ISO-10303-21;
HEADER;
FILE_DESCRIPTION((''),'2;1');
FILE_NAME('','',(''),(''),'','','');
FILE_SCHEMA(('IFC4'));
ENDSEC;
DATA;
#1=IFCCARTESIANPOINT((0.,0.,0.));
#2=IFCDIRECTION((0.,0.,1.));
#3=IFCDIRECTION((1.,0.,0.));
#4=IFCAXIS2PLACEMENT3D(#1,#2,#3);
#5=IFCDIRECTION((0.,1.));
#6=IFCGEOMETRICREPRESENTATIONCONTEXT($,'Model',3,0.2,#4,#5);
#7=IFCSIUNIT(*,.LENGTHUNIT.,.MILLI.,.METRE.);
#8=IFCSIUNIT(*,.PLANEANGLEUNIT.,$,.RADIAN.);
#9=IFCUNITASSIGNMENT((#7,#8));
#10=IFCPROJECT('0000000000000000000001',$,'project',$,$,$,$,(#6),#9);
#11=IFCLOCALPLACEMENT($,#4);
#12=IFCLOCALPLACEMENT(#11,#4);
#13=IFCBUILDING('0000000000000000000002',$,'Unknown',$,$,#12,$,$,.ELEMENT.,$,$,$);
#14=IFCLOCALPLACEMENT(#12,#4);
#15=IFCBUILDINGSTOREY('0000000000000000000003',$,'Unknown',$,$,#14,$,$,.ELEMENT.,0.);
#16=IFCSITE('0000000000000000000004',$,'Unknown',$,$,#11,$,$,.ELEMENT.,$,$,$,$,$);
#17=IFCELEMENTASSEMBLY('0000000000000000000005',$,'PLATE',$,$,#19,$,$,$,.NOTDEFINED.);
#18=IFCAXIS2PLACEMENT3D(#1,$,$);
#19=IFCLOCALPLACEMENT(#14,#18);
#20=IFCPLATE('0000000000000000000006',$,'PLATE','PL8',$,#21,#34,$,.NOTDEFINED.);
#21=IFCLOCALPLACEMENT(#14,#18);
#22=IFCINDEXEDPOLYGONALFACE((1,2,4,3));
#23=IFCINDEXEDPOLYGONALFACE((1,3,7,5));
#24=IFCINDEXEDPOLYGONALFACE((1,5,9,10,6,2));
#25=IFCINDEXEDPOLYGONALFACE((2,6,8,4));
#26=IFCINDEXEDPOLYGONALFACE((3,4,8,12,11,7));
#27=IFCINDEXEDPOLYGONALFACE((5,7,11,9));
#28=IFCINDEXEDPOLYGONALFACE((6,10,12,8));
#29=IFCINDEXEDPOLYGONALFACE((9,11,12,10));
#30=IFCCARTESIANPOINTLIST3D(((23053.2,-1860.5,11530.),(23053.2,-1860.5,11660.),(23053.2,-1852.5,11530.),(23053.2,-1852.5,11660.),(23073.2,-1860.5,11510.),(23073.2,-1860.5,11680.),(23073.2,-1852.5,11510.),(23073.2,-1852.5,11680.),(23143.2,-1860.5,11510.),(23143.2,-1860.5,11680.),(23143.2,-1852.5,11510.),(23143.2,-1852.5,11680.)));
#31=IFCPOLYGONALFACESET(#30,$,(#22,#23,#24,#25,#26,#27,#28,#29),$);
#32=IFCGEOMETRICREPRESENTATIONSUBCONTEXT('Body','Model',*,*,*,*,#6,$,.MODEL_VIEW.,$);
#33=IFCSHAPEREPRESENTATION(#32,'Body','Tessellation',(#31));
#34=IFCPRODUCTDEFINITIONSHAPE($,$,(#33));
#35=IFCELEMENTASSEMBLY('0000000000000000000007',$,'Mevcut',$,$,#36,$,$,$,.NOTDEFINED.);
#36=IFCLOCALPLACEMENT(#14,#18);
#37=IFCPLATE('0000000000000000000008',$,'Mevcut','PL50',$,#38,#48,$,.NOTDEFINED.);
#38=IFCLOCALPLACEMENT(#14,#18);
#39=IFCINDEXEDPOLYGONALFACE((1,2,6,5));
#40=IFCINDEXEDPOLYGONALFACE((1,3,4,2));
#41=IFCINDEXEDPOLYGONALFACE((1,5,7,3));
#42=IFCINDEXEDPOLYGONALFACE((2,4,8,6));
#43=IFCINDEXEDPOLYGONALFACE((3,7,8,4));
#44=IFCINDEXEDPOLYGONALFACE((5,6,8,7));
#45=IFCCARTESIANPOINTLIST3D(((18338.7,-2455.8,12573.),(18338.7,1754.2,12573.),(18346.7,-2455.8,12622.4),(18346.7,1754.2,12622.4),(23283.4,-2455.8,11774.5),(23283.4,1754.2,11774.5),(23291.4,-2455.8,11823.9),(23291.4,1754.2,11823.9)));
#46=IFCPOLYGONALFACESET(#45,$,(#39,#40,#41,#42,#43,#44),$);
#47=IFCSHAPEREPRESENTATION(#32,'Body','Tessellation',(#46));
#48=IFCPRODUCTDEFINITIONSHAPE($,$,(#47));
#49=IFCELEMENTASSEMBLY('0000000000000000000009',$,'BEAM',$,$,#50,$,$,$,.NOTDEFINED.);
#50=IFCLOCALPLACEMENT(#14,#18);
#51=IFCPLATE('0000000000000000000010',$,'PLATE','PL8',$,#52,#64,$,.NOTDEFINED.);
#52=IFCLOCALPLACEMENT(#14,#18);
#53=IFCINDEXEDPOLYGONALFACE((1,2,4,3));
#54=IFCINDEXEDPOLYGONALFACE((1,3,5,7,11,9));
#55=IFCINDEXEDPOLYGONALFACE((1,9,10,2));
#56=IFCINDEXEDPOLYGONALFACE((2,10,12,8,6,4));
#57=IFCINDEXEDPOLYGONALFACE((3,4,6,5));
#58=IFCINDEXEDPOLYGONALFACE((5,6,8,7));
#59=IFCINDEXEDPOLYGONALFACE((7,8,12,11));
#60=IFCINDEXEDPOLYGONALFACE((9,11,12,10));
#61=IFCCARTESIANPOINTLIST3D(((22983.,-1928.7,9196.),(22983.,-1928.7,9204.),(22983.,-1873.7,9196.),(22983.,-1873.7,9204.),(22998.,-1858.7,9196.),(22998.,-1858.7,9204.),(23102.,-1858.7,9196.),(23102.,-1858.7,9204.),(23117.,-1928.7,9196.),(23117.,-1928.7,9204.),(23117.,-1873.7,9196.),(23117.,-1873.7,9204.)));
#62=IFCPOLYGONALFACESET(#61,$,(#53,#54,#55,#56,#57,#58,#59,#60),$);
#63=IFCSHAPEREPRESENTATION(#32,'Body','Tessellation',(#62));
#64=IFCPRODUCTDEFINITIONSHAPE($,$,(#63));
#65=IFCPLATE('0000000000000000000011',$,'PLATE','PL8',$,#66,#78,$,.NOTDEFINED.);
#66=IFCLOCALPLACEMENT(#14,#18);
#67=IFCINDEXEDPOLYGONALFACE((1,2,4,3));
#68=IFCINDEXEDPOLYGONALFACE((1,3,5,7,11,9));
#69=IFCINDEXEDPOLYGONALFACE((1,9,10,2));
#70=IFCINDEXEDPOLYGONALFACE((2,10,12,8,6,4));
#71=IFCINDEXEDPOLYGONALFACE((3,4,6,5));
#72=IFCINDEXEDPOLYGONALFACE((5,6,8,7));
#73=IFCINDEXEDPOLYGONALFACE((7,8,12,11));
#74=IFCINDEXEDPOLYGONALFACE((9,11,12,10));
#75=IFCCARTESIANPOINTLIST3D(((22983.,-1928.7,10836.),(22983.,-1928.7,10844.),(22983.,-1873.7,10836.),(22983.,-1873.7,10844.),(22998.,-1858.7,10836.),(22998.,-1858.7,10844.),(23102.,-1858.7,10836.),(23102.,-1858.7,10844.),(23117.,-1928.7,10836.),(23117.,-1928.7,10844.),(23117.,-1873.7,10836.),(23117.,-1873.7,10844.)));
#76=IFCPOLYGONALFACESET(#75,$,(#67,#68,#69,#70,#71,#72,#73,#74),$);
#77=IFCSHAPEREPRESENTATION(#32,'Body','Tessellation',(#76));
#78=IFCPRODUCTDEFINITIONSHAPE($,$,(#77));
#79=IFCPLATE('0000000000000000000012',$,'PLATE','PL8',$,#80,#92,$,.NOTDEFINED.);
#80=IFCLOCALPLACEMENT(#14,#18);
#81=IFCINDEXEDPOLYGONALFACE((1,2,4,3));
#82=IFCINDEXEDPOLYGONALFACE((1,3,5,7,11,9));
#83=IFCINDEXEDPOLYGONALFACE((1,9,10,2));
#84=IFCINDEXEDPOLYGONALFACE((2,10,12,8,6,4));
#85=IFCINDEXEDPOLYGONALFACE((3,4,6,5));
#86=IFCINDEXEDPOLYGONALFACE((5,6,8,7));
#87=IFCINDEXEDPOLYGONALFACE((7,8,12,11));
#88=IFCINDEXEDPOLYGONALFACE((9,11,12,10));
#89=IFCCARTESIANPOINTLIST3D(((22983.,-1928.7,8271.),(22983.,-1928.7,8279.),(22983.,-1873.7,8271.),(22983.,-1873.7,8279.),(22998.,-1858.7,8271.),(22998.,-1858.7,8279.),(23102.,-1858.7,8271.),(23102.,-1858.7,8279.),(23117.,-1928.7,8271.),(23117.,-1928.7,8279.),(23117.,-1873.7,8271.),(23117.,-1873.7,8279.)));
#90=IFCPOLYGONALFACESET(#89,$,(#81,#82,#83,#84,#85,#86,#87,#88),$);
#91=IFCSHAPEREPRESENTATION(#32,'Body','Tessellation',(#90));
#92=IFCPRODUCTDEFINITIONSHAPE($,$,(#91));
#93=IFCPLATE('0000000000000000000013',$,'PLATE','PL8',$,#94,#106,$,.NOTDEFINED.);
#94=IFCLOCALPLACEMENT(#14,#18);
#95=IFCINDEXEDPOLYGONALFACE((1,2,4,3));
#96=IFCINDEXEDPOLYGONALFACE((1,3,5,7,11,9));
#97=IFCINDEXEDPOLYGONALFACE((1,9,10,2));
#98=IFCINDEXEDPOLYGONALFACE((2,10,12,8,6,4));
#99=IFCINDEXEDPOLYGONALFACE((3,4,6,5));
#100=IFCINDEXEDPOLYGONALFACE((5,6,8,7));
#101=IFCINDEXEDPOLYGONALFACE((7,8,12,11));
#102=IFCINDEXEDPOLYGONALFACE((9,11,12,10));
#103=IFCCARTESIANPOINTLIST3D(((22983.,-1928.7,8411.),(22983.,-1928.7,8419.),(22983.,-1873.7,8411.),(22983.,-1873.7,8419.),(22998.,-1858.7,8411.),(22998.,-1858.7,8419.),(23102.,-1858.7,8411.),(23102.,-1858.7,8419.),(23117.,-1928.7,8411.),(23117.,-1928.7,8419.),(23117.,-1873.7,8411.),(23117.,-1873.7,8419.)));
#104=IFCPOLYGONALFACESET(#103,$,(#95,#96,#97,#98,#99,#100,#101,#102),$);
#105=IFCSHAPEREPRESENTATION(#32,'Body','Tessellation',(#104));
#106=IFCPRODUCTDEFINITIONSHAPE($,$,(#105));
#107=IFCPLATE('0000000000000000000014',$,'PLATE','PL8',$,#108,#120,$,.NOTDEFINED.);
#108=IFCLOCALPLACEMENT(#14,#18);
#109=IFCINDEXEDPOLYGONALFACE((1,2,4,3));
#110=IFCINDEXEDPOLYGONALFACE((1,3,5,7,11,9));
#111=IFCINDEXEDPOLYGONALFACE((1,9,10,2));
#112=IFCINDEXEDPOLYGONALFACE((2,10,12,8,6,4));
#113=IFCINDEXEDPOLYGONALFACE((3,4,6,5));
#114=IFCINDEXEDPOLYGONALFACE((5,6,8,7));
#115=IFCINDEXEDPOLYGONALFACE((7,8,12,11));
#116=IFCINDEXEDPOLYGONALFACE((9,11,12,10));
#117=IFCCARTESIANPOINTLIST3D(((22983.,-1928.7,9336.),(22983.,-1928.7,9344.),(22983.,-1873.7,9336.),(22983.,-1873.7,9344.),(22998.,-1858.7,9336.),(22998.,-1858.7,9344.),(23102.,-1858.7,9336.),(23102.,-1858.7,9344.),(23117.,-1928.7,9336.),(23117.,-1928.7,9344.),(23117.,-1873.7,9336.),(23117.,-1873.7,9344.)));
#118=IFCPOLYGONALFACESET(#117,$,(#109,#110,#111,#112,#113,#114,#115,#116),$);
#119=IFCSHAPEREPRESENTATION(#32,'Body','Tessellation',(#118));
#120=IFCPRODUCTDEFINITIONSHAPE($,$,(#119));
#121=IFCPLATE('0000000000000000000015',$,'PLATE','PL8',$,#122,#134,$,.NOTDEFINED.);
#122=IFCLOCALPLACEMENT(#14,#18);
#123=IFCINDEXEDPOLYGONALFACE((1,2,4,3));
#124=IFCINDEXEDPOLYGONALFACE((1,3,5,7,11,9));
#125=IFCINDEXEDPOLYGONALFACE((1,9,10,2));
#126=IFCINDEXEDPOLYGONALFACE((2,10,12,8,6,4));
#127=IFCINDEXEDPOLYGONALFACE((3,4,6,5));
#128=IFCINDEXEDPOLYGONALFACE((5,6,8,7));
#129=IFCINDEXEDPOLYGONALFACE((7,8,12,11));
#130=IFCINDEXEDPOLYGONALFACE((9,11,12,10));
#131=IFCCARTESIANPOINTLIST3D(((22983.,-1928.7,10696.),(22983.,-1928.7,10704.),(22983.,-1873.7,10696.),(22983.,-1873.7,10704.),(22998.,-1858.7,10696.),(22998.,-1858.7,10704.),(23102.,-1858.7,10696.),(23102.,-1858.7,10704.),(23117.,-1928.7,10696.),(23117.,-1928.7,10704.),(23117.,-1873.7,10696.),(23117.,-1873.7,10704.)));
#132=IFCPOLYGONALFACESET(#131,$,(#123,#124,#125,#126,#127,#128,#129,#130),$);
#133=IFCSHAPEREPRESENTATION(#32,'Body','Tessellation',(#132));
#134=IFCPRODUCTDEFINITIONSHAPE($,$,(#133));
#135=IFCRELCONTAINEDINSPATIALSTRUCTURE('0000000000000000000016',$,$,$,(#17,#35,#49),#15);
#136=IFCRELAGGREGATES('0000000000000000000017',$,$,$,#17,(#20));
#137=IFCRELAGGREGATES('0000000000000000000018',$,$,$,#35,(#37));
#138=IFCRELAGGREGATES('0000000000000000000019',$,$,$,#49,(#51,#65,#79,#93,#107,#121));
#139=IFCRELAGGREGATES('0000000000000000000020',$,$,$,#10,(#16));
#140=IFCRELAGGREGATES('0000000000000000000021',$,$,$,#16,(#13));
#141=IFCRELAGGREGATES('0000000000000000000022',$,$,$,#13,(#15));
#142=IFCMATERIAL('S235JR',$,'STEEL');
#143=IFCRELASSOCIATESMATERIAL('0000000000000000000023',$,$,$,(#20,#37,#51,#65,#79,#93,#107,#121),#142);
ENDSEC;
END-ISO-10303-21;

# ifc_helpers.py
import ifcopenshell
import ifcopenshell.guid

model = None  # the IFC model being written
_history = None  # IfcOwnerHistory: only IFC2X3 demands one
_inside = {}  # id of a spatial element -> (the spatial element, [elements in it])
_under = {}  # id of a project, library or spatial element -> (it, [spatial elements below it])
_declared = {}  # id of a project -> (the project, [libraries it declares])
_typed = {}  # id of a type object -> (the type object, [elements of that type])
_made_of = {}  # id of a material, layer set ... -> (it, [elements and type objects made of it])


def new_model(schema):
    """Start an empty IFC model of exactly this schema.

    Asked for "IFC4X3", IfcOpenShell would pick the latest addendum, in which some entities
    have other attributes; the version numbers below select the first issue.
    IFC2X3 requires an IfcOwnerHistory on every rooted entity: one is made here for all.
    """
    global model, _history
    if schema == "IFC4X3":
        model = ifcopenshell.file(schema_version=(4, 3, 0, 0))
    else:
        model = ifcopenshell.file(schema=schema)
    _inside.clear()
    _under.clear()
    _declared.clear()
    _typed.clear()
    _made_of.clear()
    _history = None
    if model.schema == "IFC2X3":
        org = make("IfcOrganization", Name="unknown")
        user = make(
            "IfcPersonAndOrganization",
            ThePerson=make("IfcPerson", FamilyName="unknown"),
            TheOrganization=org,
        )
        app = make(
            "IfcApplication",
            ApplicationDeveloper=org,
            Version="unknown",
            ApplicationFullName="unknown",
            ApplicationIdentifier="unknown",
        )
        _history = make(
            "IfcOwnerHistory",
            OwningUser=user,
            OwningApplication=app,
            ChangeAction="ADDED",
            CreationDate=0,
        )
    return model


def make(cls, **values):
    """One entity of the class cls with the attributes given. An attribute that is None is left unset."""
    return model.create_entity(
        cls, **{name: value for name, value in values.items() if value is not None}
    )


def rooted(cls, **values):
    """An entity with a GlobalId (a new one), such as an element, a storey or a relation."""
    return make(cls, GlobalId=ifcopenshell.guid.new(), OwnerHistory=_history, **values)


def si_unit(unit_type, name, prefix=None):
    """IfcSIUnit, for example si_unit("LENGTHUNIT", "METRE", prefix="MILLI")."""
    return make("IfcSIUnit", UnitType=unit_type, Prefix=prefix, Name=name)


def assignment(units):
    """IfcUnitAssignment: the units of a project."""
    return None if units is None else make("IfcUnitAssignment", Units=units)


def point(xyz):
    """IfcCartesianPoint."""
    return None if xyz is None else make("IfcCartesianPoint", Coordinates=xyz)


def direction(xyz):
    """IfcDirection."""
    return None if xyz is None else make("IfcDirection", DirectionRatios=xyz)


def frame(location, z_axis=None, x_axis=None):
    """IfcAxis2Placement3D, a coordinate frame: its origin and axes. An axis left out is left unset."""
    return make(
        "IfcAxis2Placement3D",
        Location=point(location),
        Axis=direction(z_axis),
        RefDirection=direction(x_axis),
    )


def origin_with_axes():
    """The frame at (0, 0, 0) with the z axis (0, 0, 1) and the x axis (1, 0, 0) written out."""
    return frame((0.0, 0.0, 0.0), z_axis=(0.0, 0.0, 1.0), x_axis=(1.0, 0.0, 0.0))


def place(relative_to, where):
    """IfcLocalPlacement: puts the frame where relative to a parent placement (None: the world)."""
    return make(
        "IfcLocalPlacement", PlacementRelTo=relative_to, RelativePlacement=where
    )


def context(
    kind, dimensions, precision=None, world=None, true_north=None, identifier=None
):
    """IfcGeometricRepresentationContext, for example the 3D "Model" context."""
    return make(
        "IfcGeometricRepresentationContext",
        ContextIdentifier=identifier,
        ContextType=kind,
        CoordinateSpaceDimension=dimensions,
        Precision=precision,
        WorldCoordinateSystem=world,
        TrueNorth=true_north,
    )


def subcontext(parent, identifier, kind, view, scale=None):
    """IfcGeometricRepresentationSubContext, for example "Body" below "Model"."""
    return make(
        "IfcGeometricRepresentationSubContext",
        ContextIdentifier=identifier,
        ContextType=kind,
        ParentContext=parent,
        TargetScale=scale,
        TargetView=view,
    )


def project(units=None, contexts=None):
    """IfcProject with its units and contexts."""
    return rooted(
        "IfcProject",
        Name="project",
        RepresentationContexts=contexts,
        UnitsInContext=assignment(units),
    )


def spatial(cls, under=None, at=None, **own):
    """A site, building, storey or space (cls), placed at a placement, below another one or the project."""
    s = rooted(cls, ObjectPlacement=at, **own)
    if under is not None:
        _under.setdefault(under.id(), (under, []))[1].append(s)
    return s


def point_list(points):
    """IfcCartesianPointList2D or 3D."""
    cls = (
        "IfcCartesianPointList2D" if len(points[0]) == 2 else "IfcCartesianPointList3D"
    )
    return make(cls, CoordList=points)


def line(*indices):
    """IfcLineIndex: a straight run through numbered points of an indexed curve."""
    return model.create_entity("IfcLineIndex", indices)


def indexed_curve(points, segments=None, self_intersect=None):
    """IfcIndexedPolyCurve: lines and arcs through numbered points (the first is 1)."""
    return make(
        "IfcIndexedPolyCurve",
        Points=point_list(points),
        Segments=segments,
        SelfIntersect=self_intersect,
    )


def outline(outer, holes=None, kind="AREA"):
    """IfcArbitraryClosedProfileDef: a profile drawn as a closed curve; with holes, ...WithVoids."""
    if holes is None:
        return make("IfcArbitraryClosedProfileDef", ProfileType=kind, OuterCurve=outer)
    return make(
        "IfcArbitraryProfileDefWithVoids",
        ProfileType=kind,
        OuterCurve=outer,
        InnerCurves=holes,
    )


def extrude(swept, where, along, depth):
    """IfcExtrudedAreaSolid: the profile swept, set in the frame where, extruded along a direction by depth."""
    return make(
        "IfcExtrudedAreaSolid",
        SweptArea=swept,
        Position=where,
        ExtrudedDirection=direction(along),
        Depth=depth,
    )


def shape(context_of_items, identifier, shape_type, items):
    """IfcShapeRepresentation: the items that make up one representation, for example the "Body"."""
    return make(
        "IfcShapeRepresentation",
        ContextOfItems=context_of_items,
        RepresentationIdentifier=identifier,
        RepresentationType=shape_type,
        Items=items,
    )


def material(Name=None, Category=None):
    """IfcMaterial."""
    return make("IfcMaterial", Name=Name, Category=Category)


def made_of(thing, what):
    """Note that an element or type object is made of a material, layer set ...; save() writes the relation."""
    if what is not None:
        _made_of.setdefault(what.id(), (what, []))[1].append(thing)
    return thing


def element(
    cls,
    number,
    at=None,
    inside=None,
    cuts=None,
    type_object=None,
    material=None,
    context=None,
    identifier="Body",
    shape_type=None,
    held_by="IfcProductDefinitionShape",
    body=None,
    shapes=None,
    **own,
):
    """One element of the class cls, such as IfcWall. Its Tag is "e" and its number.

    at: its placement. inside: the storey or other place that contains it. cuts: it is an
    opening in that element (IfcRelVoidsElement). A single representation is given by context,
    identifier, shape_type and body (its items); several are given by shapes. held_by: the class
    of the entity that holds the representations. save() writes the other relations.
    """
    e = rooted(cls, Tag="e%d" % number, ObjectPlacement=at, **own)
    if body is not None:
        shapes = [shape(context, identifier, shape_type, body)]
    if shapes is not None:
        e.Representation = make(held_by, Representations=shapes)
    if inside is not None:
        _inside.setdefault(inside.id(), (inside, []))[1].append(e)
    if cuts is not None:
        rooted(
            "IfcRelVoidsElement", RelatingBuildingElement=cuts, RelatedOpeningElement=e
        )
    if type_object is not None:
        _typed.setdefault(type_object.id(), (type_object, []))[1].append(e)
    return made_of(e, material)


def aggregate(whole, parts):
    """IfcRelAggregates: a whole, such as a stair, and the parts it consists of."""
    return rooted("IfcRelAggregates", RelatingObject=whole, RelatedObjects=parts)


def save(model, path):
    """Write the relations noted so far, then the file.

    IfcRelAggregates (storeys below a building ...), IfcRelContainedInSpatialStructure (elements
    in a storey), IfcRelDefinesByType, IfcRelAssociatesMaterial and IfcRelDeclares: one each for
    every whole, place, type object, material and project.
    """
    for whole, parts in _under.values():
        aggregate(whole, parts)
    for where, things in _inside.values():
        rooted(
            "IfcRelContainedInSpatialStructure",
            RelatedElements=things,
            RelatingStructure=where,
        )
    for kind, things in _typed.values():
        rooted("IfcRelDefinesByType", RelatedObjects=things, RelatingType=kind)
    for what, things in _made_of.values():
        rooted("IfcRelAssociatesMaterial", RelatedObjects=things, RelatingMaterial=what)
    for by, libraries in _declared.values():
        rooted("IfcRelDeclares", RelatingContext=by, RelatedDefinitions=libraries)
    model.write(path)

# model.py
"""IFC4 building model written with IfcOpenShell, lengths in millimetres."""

from ifc_helpers import new_model, si_unit, direction, frame, origin_with_axes, place, context, subcontext, project, spatial, line, indexed_curve, outline, extrude, material, element, aggregate, save


model = new_model("IFC4")

# Units and contexts
model_context = context("Model", 3, precision=0.2, world=origin_with_axes(), true_north=direction((0.0, 1.0)))
body_context = subcontext(model_context, "Body", "Model", "MODEL_VIEW")
ifc_project = project(units=[si_unit("LENGTHUNIT", "METRE", prefix="MILLI"), si_unit("PLANEANGLEUNIT", "RADIAN")], contexts=[model_context])

# Site, building, storey
site_placement = place(None, origin_with_axes())
site = spatial("IfcSite", under=ifc_project, at=site_placement, Name="Unknown", CompositionType="ELEMENT")
building_placement = place(site_placement, origin_with_axes())
building = spatial("IfcBuilding", under=site, at=building_placement, Name="Unknown", CompositionType="ELEMENT")
storey_placement = place(building_placement, origin_with_axes())
storey = spatial("IfcBuildingStorey", under=building, at=storey_placement, Name="Unknown", CompositionType="ELEMENT", Elevation=0.0)

# Shared definitions
ifc_material = material(Name="S235JR", Category="STEEL")

# Element assemblies, plates
assembly_1_placement = place(storey_placement, frame((23053.2, -1856.5, 11510.0), z_axis=(0.0, -1.0, 0.0), x_axis=(1.0, 0.0, 0.0)))
assembly_1 = element("IfcElementAssembly", 1, at=assembly_1_placement, inside=storey, Name="PLATE", PredefinedType="NOTDEFINED")
plate_1_placement = place(assembly_1_placement, origin_with_axes())
plate_1 = element("IfcPlate", 2, at=plate_1_placement, material=ifc_material, Name="PLATE", Description="PL8", PredefinedType="NOTDEFINED", context=body_context, shape_type="SolidModel", body=[
    extrude(outline(indexed_curve([(0.0, 20.0), (20.0, 0.0), (90.0, 0.0), (90.0, 170.0), (20.0, 170.0), (0.0, 150.0)], segments=[line(1, 2, 3, 4, 5, 6, 1)])), frame((0.0, 0.0, 4.0), z_axis=(0.0, 0.0, 1.0), x_axis=(1.0, 0.0, 0.0)), (0.0, 0.0, -1.0), 8.0),
])
aggregate(assembly_1, [plate_1])
assembly_2_placement = place(storey_placement, frame((18342.7, 1754.2, 12597.7), z_axis=(0.159427, 0.0, 0.98721), x_axis=(0.0, -1.0, 0.0)))
assembly_2 = element("IfcElementAssembly", 3, at=assembly_2_placement, inside=storey, Name="Mevcut", PredefinedType="NOTDEFINED")
plate_2_placement = place(assembly_2_placement, origin_with_axes())
plate_2 = element("IfcPlate", 4, at=plate_2_placement, material=ifc_material, Name="Mevcut", Description="PL50", PredefinedType="NOTDEFINED", context=body_context, shape_type="SolidModel", body=[
    extrude(outline(indexed_curve([(0.0, 0.0), (4210.0, 0.0), (4210.0, 5008.7), (0.0, 5008.7)], segments=[line(1, 2, 3, 4, 1)])), frame((0.0, 0.0, 25.0), z_axis=(0.0, 0.0, 1.0), x_axis=(1.0, 0.0, 0.0)), (0.0, 0.0, -1.0), 50.0),
])
aggregate(assembly_2, [plate_2])

# Element assembly, plates
assembly_3_placement = place(storey_placement, frame((23050.0, -1854.9, 11625.0), z_axis=(0.0, -1.0, 0.0), x_axis=(0.0, 0.0, -1.0)))
assembly_3 = element("IfcElementAssembly", 5, at=assembly_3_placement, inside=storey, Name="BEAM", PredefinedType="NOTDEFINED")
plate_3_placement = place(assembly_3_placement, frame((2425.0, -67.0, 3.8), z_axis=(-1.0, 0.0, 0.0), x_axis=(0.0, 0.0, 1.0)))
plate_3 = element("IfcPlate", 6, at=plate_3_placement, material=ifc_material, Name="PLATE", Description="PL8", PredefinedType="NOTDEFINED", context=body_context, shape_type="SolidModel", body=[
    extrude(outline(indexed_curve([(0.0, 15.0), (15.0, 0.0), (70.0, 0.0), (70.0, 134.0), (15.0, 134.0), (0.0, 119.0)], segments=[line(1, 2, 3, 4, 5, 6, 1)])), frame((0.0, 0.0, 4.0), z_axis=(0.0, 0.0, 1.0), x_axis=(1.0, 0.0, 0.0)), (0.0, 0.0, -1.0), 8.0),
])
plate_4_placement = place(assembly_3_placement, frame((785.0, -67.0, 3.8), z_axis=(-1.0, 0.0, 0.0), x_axis=(0.0, 0.0, 1.0)))
plate_4 = element("IfcPlate", 7, at=plate_4_placement, material=ifc_material, Name="PLATE", Description="PL8", PredefinedType="NOTDEFINED", context=body_context, shape_type="SolidModel", body=[
    extrude(outline(indexed_curve([(0.0, 15.0), (15.0, 0.0), (70.0, 0.0), (70.0, 134.0), (15.0, 134.0), (0.0, 119.0)], segments=[line(1, 2, 3, 4, 5, 6, 1)])), frame((0.0, 0.0, 4.0), z_axis=(0.0, 0.0, 1.0), x_axis=(1.0, 0.0, 0.0)), (0.0, 0.0, -1.0), 8.0),
])
plate_5_placement = place(assembly_3_placement, frame((3350.0, -67.0, 3.8), z_axis=(-1.0, 0.0, 0.0), x_axis=(0.0, 0.0, 1.0)))
plate_5 = element("IfcPlate", 8, at=plate_5_placement, material=ifc_material, Name="PLATE", Description="PL8", PredefinedType="NOTDEFINED", context=body_context, shape_type="SolidModel", body=[
    extrude(outline(indexed_curve([(0.0, 15.0), (15.0, 0.0), (70.0, 0.0), (70.0, 134.0), (15.0, 134.0), (0.0, 119.0)], segments=[line(1, 2, 3, 4, 5, 6, 1)])), frame((0.0, 0.0, 4.0), z_axis=(0.0, 0.0, 1.0), x_axis=(1.0, 0.0, 0.0)), (0.0, 0.0, -1.0), 8.0),
])
plate_6_placement = place(assembly_3_placement, frame((3210.0, -67.0, 3.8), z_axis=(-1.0, 0.0, 0.0), x_axis=(0.0, 0.0, 1.0)))
plate_6 = element("IfcPlate", 9, at=plate_6_placement, material=ifc_material, Name="PLATE", Description="PL8", PredefinedType="NOTDEFINED", context=body_context, shape_type="SolidModel", body=[
    extrude(outline(indexed_curve([(0.0, 15.0), (15.0, 0.0), (70.0, 0.0), (70.0, 134.0), (15.0, 134.0), (0.0, 119.0)], segments=[line(1, 2, 3, 4, 5, 6, 1)])), frame((0.0, 0.0, 4.0), z_axis=(0.0, 0.0, 1.0), x_axis=(1.0, 0.0, 0.0)), (0.0, 0.0, -1.0), 8.0),
])
plate_7_placement = place(assembly_3_placement, frame((2285.0, -67.0, 3.8), z_axis=(-1.0, 0.0, 0.0), x_axis=(0.0, 0.0, 1.0)))
plate_7 = element("IfcPlate", 10, at=plate_7_placement, material=ifc_material, Name="PLATE", Description="PL8", PredefinedType="NOTDEFINED", context=body_context, shape_type="SolidModel", body=[
    extrude(outline(indexed_curve([(0.0, 15.0), (15.0, 0.0), (70.0, 0.0), (70.0, 134.0), (15.0, 134.0), (0.0, 119.0)], segments=[line(1, 2, 3, 4, 5, 6, 1)])), frame((0.0, 0.0, 4.0), z_axis=(0.0, 0.0, 1.0), x_axis=(1.0, 0.0, 0.0)), (0.0, 0.0, -1.0), 8.0),
])
plate_8_placement = place(assembly_3_placement, frame((925.0, -67.0, 3.8), z_axis=(-1.0, 0.0, 0.0), x_axis=(0.0, 0.0, 1.0)))
plate_8 = element("IfcPlate", 11, at=plate_8_placement, material=ifc_material, Name="PLATE", Description="PL8", PredefinedType="NOTDEFINED", context=body_context, shape_type="SolidModel", body=[
    extrude(outline(indexed_curve([(0.0, 15.0), (15.0, 0.0), (70.0, 0.0), (70.0, 134.0), (15.0, 134.0), (0.0, 119.0)], segments=[line(1, 2, 3, 4, 5, 6, 1)])), frame((0.0, 0.0, 4.0), z_axis=(0.0, 0.0, 1.0), x_axis=(1.0, 0.0, 0.0)), (0.0, 0.0, -1.0), 8.0),
])
aggregate(assembly_3, [plate_3, plate_4, plate_5, plate_6, plate_7, plate_8])

save(model, "model.ifc")
